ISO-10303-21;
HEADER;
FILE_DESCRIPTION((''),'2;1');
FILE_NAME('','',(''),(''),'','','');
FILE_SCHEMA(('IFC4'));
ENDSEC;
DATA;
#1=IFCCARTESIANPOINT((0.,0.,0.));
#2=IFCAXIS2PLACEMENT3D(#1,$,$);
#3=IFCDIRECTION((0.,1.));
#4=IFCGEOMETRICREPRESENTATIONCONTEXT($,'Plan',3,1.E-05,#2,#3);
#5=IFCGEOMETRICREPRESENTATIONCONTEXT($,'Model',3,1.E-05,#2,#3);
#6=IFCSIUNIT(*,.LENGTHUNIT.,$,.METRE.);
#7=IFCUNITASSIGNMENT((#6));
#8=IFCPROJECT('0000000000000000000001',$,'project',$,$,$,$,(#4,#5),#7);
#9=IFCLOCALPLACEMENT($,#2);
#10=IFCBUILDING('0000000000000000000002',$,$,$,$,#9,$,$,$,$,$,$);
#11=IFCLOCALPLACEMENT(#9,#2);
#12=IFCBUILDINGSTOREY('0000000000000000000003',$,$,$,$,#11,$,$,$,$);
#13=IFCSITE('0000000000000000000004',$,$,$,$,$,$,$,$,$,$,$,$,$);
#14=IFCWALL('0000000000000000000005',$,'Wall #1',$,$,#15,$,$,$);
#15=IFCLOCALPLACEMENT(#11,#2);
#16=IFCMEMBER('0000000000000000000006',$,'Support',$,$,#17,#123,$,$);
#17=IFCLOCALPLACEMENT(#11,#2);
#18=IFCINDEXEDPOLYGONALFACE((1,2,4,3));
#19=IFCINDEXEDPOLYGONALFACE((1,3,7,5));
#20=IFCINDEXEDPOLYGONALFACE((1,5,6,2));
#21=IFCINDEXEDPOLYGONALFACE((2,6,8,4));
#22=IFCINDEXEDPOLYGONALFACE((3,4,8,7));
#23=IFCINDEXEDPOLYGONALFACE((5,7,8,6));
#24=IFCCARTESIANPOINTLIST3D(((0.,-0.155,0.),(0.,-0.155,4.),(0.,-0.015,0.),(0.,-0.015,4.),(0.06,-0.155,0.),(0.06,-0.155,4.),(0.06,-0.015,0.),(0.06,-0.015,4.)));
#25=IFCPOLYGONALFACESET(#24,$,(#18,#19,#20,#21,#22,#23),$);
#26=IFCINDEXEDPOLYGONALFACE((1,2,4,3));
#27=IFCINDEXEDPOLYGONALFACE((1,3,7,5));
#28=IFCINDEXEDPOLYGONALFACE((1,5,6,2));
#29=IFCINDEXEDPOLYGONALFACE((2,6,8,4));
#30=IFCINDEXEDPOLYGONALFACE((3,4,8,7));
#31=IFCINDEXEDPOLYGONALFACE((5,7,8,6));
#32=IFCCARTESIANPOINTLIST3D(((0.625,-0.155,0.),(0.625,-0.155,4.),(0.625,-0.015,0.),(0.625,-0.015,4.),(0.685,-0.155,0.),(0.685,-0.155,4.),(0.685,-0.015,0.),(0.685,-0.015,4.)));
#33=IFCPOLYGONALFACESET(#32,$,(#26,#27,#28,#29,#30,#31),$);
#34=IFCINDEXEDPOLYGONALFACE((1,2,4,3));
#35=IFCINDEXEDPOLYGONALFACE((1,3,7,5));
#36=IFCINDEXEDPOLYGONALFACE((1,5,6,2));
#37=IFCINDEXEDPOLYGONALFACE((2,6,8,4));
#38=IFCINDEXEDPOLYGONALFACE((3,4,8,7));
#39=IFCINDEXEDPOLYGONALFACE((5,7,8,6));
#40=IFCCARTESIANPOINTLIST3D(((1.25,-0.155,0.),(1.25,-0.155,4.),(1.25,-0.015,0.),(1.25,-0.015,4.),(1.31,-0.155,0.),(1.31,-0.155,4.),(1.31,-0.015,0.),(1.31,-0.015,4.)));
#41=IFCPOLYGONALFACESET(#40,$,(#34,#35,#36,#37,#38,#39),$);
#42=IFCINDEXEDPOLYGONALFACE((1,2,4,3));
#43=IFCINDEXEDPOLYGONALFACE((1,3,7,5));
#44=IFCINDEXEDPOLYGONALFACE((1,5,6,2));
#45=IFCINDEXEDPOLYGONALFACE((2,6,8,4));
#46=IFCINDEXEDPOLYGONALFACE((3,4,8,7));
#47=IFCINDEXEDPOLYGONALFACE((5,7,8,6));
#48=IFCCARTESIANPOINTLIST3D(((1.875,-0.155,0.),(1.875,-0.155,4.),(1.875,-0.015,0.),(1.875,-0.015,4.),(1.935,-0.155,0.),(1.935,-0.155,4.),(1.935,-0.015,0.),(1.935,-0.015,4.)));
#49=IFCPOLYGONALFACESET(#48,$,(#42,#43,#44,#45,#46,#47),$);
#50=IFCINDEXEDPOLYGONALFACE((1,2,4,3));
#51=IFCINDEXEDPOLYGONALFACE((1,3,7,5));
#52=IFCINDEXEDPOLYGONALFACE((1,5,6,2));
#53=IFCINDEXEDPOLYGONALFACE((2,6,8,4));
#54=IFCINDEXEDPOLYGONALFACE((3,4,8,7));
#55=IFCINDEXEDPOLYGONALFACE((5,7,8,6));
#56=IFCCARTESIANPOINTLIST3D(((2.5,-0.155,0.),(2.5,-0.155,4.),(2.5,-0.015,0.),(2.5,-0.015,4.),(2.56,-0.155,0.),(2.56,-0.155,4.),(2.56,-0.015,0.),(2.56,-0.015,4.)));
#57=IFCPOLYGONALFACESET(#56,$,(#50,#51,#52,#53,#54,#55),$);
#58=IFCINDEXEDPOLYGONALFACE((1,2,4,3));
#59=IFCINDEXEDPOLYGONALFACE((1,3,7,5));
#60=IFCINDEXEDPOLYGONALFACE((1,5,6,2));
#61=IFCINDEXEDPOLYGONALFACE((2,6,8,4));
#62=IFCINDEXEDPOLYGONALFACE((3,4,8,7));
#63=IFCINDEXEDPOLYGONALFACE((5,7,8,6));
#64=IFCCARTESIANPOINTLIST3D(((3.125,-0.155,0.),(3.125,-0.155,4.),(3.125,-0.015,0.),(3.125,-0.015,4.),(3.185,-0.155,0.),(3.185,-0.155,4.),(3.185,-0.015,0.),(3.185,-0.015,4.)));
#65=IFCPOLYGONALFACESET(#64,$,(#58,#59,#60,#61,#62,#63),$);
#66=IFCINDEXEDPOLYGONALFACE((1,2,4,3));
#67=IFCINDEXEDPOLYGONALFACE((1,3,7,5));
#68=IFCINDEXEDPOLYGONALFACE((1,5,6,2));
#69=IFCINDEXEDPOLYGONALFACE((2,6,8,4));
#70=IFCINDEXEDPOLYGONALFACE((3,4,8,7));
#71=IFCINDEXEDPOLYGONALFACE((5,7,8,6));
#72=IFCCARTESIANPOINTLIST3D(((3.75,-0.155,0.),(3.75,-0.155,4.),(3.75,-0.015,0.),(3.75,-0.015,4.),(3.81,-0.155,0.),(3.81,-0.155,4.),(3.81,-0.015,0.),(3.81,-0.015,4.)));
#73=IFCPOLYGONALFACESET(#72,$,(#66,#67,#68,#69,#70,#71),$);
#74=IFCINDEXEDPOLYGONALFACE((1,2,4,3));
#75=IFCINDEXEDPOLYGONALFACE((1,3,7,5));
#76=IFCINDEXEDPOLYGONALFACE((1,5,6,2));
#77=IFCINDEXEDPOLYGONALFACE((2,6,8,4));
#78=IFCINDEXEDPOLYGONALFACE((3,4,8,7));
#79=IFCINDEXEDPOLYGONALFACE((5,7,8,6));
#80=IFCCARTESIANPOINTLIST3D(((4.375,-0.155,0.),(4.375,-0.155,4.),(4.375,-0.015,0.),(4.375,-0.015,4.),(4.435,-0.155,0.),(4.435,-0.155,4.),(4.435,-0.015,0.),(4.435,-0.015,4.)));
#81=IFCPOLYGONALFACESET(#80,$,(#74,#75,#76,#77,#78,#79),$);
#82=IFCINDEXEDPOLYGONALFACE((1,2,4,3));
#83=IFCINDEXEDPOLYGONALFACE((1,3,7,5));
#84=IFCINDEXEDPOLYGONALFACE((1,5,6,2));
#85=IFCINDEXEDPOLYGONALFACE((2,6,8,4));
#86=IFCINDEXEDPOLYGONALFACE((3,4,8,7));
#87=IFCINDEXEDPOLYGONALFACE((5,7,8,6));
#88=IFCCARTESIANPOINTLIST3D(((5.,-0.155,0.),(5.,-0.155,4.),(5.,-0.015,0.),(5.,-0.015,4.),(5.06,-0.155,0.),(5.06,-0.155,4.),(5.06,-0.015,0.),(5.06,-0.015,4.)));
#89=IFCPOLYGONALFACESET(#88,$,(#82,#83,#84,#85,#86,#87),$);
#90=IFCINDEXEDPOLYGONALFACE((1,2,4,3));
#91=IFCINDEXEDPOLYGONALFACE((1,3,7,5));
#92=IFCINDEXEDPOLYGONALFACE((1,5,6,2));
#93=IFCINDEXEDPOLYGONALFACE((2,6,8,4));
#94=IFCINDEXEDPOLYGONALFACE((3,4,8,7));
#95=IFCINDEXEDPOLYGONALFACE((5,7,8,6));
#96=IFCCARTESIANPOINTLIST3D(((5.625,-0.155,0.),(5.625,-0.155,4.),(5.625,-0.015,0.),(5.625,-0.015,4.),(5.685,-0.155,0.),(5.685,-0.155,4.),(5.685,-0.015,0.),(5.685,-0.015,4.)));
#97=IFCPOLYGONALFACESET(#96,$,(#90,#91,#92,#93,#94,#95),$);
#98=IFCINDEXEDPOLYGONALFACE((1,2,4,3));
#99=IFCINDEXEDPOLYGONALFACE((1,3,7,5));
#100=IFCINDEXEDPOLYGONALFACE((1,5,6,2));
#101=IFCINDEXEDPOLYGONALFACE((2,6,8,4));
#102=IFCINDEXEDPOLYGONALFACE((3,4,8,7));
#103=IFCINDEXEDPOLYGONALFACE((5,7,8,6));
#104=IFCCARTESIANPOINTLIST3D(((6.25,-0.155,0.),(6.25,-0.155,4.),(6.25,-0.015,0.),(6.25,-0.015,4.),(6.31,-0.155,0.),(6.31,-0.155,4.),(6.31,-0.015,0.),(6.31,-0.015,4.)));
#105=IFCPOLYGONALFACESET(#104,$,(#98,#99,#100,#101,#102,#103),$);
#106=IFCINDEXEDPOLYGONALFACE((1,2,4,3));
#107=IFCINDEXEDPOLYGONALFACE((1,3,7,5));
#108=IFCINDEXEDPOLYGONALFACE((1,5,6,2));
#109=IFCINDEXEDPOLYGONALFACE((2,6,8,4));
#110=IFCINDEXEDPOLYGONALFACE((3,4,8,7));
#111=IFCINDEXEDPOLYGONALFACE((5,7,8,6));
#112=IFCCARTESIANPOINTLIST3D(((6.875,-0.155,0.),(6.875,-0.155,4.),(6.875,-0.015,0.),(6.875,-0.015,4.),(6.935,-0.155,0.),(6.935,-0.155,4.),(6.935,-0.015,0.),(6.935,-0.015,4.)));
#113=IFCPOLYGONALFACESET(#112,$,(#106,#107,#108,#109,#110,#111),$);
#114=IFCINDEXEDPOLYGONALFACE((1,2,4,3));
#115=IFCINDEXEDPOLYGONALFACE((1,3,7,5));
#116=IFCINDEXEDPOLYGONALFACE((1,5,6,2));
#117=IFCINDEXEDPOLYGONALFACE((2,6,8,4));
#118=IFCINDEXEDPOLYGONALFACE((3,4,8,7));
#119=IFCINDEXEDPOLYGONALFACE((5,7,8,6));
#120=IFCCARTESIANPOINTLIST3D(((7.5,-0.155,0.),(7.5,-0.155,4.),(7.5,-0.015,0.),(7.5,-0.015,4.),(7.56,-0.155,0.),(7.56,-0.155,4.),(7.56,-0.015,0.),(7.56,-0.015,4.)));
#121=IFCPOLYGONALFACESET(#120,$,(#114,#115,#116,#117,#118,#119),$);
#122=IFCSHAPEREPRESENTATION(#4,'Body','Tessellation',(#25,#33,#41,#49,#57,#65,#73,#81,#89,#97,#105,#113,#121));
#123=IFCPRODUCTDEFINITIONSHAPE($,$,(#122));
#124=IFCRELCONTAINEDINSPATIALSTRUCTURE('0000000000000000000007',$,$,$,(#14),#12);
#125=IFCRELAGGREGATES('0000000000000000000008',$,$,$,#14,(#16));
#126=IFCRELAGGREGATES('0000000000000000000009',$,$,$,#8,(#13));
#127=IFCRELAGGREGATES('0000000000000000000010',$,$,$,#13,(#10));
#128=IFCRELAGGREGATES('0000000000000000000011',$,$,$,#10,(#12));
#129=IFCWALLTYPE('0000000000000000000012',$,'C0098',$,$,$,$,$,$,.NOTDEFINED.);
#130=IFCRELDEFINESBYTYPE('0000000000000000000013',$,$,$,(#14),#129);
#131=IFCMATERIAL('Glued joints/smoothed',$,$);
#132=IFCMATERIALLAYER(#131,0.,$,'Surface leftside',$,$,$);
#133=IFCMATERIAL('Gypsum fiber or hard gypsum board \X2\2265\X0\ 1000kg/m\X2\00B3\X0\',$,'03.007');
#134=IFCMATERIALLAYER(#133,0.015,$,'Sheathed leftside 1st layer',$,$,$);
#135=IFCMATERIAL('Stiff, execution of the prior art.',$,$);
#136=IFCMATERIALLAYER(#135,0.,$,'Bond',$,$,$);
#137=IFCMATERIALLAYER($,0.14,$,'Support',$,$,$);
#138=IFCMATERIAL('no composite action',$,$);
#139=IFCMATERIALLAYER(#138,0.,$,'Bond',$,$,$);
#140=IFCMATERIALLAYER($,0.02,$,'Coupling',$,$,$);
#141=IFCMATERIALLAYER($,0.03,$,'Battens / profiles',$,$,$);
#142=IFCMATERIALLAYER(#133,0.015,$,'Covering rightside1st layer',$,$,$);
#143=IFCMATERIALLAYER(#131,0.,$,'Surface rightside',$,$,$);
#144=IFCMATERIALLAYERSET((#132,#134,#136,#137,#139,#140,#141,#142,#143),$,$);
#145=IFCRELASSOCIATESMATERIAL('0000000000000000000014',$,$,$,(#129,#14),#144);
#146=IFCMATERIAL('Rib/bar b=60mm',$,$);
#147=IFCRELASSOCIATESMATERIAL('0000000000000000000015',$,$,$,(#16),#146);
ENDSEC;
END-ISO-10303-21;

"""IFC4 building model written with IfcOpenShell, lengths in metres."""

from ifc_helpers import new_model, si_unit, direction, frame, frame_2d, origin, place, context, project, spatial, rectangle, extrude, material, layer, layer_set, type_object, element, aggregate, save


model = new_model("IFC4")

# Units and contexts
plan_context = context("Plan", 3, precision=1e-05, world=origin(), true_north=direction((0.0, 1.0)))
model_context = context("Model", 3, precision=1e-05, world=origin(), true_north=direction((0.0, 1.0)))
ifc_project = project(units=[si_unit("LENGTHUNIT", "METRE")], contexts=[plan_context, model_context])

# Site, building, storey
site = spatial("IfcSite", under=ifc_project)
building_placement = place(None, origin())
building = spatial("IfcBuilding", under=site, at=building_placement)
storey_placement = place(building_placement, origin())
storey = spatial("IfcBuildingStorey", under=building, at=storey_placement)

# Wall, member
ifc_material_1 = material(Name="Glued joints/smoothed")
ifc_layer_1 = layer(ifc_material_1, 0.0, Name="Surface leftside")
ifc_material_2 = material(Name="Gypsum fiber or hard gypsum board ≥ 1000kg/m³", Category="03.007")
ifc_layer_2 = layer(ifc_material_2, 0.015, Name="Sheathed leftside 1st layer")
ifc_material_3 = material(Name="Stiff, execution of the prior art.")
ifc_layer_3 = layer(ifc_material_3, 0.0, Name="Bond")
ifc_layer_4 = layer(None, 0.14, Name="Support")
ifc_material_4 = material(Name="no composite action")
ifc_layer_5 = layer(ifc_material_4, 0.0, Name="Bond")
ifc_layer_6 = layer(None, 0.02, Name="Coupling")
ifc_layer_7 = layer(None, 0.03, Name="Battens / profiles")
ifc_layer_8 = layer(ifc_material_2, 0.015, Name="Covering rightside1st layer")
ifc_layer_9 = layer(ifc_material_1, 0.0, Name="Surface rightside")
ifc_layer_set = layer_set([ifc_layer_1, ifc_layer_2, ifc_layer_3, ifc_layer_4, ifc_layer_5, ifc_layer_6, ifc_layer_7, ifc_layer_8, ifc_layer_9])
wall_type = type_object("IfcWallType", Name="C0098", PredefinedType="NOTDEFINED", material=ifc_layer_set)
wall_placement = place(None, frame((0.0, 0.0, 0.0), z_axis=(0.0, -1.0, 0.0), x_axis=(1.0, 0.0, 0.0)))
wall = element("IfcWall", 1, at=wall_placement, inside=storey, type_object=wall_type, material=ifc_layer_set, Name="Wall #1")
ifc_material_5 = material(Name="Rib/bar b=60mm")
member_1_placement = place(wall_placement, origin())
member_1 = element("IfcMember", 2, at=member_1_placement, material=ifc_material_5, Name="Support", context=plan_context, shape_type="SweptSolid", body=[
    extrude(rectangle(XDim=0.06, YDim=0.14, at=frame_2d((0.03, 0.07), x_axis=(1.0, 0.0))), frame((0.0, 4.0, 0.015), z_axis=(0.0, -1.0, 0.0), x_axis=(1.0, 0.0, 0.0)), (0.0, 0.0, 1.0), 4.0),
    extrude(rectangle(XDim=0.06, YDim=0.14, at=frame_2d((0.03, 0.07), x_axis=(1.0, 0.0))), frame((0.625, 4.0, 0.015), z_axis=(0.0, -1.0, 0.0), x_axis=(1.0, 0.0, 0.0)), (0.0, 0.0, 1.0), 4.0),
    extrude(rectangle(XDim=0.06, YDim=0.14, at=frame_2d((0.03, 0.07), x_axis=(1.0, 0.0))), frame((1.25, 4.0, 0.015), z_axis=(0.0, -1.0, 0.0), x_axis=(1.0, 0.0, 0.0)), (0.0, 0.0, 1.0), 4.0),
    extrude(rectangle(XDim=0.06, YDim=0.14, at=frame_2d((0.03, 0.07), x_axis=(1.0, 0.0))), frame((1.875, 4.0, 0.015), z_axis=(0.0, -1.0, 0.0), x_axis=(1.0, 0.0, 0.0)), (0.0, 0.0, 1.0), 4.0),
    extrude(rectangle(XDim=0.06, YDim=0.14, at=frame_2d((0.03, 0.07), x_axis=(1.0, 0.0))), frame((2.5, 4.0, 0.015), z_axis=(0.0, -1.0, 0.0), x_axis=(1.0, 0.0, 0.0)), (0.0, 0.0, 1.0), 4.0),
    extrude(rectangle(XDim=0.06, YDim=0.14, at=frame_2d((0.03, 0.07), x_axis=(1.0, 0.0))), frame((3.125, 4.0, 0.015), z_axis=(0.0, -1.0, 0.0), x_axis=(1.0, 0.0, 0.0)), (0.0, 0.0, 1.0), 4.0),
    extrude(rectangle(XDim=0.06, YDim=0.14, at=frame_2d((0.03, 0.07), x_axis=(1.0, 0.0))), frame((3.75, 4.0, 0.015), z_axis=(0.0, -1.0, 0.0), x_axis=(1.0, 0.0, 0.0)), (0.0, 0.0, 1.0), 4.0),
    extrude(rectangle(XDim=0.06, YDim=0.14, at=frame_2d((0.03, 0.07), x_axis=(1.0, 0.0))), frame((4.375, 4.0, 0.015), z_axis=(0.0, -1.0, 0.0), x_axis=(1.0, 0.0, 0.0)), (0.0, 0.0, 1.0), 4.0),
    extrude(rectangle(XDim=0.06, YDim=0.14, at=frame_2d((0.03, 0.07), x_axis=(1.0, 0.0))), frame((5.0, 4.0, 0.015), z_axis=(0.0, -1.0, 0.0), x_axis=(1.0, 0.0, 0.0)), (0.0, 0.0, 1.0), 4.0),
    extrude(rectangle(XDim=0.06, YDim=0.14, at=frame_2d((0.03, 0.07), x_axis=(1.0, 0.0))), frame((5.625, 4.0, 0.015), z_axis=(0.0, -1.0, 0.0), x_axis=(1.0, 0.0, 0.0)), (0.0, 0.0, 1.0), 4.0),
    extrude(rectangle(XDim=0.06, YDim=0.14, at=frame_2d((0.03, 0.07), x_axis=(1.0, 0.0))), frame((6.25, 4.0, 0.015), z_axis=(0.0, -1.0, 0.0), x_axis=(1.0, 0.0, 0.0)), (0.0, 0.0, 1.0), 4.0),
    extrude(rectangle(XDim=0.06, YDim=0.14, at=frame_2d((0.03, 0.07), x_axis=(1.0, 0.0))), frame((6.875, 4.0, 0.015), z_axis=(0.0, -1.0, 0.0), x_axis=(1.0, 0.0, 0.0)), (0.0, 0.0, 1.0), 4.0),
    extrude(rectangle(XDim=0.06, YDim=0.14, at=frame_2d((0.03, 0.07), x_axis=(1.0, 0.0))), frame((7.5, 4.0, 0.015), z_axis=(0.0, -1.0, 0.0), x_axis=(1.0, 0.0, 0.0)), (0.0, 0.0, 1.0), 4.0),
])
aggregate(wall, [member_1])

save(model, "model.ifc")
